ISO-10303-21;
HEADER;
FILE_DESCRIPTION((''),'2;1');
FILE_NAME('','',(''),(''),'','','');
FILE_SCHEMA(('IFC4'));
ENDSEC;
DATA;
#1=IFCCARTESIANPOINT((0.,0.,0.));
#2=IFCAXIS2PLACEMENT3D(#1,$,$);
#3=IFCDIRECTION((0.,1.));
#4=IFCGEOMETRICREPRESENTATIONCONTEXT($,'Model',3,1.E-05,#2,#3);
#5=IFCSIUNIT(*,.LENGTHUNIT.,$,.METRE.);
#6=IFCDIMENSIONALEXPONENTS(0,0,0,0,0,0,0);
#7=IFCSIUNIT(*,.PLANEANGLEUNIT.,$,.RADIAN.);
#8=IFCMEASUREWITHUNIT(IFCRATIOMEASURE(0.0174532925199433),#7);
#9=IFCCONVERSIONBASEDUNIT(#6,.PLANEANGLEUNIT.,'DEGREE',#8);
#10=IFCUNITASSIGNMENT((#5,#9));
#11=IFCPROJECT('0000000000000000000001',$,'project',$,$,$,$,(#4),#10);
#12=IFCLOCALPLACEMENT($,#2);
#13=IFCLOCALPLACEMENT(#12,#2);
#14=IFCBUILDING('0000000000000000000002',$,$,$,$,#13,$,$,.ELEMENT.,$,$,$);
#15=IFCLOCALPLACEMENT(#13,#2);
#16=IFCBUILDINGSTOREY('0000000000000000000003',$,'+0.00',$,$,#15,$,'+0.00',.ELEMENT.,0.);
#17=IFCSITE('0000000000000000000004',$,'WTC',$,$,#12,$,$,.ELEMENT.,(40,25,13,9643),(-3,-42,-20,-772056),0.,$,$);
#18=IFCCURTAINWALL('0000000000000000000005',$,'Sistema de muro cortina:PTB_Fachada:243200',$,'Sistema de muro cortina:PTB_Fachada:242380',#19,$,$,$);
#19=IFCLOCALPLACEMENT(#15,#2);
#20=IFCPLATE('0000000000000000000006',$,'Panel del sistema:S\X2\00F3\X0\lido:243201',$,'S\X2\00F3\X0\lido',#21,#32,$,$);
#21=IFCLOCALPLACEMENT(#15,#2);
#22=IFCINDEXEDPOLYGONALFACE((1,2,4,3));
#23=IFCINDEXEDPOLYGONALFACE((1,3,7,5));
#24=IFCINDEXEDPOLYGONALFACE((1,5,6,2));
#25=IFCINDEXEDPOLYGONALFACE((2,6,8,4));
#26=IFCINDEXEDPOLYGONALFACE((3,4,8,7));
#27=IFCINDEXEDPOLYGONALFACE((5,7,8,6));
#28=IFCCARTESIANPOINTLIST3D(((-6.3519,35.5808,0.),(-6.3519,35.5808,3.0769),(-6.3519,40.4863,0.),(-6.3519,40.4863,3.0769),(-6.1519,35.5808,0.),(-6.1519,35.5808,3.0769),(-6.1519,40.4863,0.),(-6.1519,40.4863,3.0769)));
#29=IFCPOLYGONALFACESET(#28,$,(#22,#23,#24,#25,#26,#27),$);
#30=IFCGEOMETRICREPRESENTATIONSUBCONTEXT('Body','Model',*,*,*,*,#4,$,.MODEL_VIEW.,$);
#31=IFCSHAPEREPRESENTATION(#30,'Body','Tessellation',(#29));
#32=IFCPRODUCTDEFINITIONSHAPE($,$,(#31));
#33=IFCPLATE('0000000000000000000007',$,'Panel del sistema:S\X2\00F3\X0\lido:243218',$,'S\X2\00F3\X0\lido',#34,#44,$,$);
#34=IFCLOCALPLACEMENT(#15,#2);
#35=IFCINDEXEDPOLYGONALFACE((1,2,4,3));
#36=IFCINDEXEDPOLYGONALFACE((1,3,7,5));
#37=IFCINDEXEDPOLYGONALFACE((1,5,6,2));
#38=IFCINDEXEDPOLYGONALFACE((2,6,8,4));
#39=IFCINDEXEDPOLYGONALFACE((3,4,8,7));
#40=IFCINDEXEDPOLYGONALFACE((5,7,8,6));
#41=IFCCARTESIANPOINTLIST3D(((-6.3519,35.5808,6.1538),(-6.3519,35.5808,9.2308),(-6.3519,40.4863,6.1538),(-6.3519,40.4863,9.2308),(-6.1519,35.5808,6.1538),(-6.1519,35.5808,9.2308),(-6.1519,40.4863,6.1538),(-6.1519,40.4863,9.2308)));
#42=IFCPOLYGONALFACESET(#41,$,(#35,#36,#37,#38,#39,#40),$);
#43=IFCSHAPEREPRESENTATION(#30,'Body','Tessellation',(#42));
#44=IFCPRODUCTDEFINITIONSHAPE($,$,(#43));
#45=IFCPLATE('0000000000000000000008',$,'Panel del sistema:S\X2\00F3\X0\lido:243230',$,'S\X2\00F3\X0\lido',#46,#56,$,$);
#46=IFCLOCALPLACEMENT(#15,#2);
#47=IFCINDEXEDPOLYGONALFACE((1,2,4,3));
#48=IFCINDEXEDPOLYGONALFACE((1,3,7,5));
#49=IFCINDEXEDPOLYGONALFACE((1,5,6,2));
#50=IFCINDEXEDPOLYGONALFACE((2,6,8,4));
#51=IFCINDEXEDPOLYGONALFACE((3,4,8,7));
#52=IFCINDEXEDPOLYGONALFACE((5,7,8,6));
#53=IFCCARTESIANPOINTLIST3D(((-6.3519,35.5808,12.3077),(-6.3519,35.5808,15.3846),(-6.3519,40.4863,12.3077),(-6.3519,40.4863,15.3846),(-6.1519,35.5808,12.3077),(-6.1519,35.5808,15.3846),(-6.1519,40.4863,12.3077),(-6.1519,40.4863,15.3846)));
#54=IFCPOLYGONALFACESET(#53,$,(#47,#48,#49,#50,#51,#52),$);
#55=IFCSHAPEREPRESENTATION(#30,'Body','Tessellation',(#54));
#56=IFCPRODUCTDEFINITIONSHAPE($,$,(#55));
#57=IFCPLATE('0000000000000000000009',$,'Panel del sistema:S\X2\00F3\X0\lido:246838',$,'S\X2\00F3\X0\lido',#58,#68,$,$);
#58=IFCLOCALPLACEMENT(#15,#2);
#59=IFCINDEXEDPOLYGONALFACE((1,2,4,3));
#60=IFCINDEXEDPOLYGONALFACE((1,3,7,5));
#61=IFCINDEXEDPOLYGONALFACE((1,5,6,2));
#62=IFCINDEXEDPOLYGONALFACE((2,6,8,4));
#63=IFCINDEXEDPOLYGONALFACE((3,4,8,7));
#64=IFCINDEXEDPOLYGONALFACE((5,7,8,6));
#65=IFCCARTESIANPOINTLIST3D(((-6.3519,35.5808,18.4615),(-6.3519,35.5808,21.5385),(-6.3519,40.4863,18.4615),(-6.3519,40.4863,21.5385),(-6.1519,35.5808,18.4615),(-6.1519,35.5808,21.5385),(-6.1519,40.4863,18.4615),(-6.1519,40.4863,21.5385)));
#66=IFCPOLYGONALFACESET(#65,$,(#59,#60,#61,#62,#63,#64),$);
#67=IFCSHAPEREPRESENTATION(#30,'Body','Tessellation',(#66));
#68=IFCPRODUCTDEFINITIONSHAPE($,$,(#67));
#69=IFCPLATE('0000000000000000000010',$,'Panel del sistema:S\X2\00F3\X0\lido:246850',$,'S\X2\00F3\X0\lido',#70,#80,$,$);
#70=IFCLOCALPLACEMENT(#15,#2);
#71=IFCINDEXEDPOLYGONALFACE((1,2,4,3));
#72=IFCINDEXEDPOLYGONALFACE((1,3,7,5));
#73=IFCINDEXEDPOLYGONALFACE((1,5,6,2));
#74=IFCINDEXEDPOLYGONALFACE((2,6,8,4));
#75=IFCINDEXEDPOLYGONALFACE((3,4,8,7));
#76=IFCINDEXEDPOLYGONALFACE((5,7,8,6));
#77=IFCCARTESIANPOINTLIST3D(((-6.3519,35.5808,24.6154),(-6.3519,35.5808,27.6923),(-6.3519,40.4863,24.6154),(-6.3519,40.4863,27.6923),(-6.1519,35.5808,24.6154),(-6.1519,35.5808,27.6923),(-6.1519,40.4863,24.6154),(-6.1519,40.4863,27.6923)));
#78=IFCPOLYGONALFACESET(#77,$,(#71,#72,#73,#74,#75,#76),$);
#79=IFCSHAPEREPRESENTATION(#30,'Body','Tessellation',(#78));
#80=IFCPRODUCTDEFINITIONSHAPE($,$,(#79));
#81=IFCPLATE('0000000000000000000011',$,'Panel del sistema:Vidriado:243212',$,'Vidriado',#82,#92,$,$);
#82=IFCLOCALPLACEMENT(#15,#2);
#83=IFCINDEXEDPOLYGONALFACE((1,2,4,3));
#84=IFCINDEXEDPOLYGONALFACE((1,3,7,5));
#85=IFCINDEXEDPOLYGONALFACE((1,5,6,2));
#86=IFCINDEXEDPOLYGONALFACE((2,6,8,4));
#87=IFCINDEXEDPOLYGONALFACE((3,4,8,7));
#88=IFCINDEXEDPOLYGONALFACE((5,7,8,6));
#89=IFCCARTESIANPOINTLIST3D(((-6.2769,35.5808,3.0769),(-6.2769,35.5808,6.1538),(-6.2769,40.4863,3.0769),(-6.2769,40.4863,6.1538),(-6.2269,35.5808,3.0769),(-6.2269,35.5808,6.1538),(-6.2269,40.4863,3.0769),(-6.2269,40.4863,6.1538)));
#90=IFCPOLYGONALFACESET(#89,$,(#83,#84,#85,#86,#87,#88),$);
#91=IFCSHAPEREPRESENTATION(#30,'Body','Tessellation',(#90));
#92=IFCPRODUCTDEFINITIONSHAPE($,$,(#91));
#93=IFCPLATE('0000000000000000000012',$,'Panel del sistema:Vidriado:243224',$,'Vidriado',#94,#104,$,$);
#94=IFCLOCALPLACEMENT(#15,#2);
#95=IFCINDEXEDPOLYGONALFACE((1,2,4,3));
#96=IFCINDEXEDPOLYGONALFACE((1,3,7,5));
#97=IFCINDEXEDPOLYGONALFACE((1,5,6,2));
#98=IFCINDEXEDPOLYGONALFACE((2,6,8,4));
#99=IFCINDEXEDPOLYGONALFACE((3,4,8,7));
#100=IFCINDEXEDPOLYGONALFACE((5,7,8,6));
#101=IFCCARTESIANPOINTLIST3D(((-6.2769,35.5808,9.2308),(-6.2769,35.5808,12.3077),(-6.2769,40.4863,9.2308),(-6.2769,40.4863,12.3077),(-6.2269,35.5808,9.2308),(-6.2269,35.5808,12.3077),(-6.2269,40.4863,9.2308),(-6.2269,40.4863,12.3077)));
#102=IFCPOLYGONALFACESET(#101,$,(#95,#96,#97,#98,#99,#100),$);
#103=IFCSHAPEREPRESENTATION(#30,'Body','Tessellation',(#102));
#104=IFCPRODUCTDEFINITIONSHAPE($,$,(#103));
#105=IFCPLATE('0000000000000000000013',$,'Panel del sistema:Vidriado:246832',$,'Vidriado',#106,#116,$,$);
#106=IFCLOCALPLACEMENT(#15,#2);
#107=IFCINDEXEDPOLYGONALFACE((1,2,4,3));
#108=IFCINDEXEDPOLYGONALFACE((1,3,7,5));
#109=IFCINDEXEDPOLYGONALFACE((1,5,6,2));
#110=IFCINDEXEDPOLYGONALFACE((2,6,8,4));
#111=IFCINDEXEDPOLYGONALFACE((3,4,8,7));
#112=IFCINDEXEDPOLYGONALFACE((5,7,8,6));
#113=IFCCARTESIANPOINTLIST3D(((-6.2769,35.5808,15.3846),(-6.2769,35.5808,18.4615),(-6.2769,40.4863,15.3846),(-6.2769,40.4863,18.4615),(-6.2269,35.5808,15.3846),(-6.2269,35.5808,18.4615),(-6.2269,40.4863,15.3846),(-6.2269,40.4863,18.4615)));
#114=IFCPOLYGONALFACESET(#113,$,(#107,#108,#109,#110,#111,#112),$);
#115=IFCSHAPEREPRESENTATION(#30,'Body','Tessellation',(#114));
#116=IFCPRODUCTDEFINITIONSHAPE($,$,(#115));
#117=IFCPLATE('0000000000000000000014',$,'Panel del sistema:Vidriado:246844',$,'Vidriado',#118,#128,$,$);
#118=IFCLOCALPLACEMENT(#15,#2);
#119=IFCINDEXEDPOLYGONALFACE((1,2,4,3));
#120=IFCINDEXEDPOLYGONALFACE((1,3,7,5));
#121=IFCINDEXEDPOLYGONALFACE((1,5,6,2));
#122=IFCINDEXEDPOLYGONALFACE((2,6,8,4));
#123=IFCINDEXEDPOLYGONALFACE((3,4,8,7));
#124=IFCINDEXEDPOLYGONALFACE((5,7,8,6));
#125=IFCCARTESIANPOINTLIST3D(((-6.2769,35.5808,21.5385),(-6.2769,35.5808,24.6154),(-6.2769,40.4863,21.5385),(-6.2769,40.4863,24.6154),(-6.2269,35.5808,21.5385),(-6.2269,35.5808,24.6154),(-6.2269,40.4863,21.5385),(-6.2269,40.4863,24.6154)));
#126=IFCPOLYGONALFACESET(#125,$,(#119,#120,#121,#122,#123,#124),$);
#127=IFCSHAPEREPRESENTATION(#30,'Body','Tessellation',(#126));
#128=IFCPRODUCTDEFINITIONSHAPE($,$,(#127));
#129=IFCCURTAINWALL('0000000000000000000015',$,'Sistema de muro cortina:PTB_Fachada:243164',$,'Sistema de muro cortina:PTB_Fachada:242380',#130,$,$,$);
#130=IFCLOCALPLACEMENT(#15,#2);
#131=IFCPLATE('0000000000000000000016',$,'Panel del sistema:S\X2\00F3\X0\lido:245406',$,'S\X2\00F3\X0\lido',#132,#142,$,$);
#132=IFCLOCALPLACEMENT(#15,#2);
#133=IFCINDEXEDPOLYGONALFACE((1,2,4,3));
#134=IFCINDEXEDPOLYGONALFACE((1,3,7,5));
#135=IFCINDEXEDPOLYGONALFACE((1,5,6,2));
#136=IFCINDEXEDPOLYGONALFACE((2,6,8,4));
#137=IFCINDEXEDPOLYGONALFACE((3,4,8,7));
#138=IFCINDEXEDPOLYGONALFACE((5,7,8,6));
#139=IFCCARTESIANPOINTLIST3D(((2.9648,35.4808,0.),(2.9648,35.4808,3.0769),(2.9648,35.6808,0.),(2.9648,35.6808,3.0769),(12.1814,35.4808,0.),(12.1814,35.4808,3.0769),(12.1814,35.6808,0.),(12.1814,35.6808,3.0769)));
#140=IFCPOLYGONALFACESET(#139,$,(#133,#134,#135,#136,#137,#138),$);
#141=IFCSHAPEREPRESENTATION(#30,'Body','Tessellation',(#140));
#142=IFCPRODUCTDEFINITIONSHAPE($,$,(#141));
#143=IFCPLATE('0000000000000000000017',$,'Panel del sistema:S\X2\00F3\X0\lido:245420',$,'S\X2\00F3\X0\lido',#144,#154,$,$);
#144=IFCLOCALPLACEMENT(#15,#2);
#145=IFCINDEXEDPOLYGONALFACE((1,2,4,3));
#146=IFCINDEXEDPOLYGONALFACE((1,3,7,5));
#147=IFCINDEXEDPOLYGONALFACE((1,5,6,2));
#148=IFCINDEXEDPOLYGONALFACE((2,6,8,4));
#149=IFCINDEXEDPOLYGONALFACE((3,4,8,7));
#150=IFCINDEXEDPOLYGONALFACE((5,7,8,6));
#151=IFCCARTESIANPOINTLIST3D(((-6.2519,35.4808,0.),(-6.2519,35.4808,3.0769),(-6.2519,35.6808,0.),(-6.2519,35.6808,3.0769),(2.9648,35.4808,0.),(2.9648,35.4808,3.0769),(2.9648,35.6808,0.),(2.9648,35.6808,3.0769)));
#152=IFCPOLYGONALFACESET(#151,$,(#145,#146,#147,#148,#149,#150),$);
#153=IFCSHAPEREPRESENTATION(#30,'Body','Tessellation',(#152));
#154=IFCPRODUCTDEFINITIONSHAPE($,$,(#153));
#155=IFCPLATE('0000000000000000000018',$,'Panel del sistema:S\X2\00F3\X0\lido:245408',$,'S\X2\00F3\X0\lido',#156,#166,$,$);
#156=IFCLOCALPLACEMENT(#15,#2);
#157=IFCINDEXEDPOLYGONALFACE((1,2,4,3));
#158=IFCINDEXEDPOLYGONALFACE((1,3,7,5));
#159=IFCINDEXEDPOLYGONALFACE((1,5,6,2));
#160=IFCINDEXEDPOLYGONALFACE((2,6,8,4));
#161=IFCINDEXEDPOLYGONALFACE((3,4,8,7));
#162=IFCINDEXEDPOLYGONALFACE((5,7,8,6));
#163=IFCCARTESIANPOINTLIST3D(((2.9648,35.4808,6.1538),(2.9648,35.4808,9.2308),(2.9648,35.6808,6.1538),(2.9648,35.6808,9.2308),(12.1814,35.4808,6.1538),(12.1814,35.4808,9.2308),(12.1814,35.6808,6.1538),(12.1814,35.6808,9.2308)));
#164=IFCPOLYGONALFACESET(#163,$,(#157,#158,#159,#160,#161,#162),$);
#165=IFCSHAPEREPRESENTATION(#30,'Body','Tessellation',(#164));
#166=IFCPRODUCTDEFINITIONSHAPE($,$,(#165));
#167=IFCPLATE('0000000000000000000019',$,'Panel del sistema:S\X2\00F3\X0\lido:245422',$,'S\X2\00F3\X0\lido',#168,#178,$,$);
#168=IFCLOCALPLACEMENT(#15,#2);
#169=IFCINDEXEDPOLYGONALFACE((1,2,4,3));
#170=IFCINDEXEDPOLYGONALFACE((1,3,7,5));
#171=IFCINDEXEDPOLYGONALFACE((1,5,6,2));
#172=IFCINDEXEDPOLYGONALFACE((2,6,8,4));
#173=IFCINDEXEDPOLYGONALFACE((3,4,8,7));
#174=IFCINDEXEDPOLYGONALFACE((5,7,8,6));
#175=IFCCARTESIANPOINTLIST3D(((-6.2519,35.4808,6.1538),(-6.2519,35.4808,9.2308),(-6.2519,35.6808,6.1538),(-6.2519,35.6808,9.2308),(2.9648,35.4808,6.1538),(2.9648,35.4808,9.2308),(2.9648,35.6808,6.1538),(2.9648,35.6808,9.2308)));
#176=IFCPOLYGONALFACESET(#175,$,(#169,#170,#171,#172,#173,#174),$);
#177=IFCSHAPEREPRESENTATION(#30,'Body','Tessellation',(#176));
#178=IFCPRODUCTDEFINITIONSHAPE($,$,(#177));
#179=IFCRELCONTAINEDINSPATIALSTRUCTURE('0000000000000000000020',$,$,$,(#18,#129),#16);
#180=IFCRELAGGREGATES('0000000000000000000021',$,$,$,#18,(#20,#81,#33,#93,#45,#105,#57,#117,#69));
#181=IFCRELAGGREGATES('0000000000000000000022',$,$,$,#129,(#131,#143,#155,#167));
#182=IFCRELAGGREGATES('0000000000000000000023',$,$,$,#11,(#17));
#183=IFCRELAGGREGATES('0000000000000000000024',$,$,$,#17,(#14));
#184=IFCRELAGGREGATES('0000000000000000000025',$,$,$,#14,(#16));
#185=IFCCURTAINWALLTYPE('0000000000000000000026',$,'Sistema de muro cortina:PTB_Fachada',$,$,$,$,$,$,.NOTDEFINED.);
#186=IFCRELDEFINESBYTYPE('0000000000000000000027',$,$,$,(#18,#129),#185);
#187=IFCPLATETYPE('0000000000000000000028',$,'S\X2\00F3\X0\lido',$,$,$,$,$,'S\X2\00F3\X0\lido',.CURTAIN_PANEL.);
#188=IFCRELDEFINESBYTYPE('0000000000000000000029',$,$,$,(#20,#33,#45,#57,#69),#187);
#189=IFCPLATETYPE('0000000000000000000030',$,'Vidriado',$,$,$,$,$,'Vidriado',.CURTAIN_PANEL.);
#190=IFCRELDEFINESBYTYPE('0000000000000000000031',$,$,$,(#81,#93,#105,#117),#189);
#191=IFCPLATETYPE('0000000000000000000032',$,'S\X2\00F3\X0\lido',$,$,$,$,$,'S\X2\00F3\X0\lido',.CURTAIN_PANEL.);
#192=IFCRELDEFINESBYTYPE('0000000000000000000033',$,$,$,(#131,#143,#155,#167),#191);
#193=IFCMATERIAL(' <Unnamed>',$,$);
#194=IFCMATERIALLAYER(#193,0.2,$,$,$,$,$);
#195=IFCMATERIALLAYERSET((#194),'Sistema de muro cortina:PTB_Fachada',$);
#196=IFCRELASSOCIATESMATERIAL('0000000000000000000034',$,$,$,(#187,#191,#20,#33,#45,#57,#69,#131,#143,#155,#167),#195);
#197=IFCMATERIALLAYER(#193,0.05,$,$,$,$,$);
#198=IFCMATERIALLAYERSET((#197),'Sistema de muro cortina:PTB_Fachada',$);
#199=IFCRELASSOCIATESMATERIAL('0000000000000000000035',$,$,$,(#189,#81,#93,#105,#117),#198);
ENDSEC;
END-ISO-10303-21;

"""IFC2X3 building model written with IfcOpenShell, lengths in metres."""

from ifc_helpers import new_model, entity, si_unit, converted_unit, direction, frame, origin, origin_2d_with_axis, place, context, subcontext, project, spatial, rectangle, extrude, source, transform, mapped, material, layer, layer_set, layer_usage, type_object, type_shapes, element, aggregate, save


model = new_model("IFC2X3")

# Units and contexts
model_context = context("Model", 3, precision=1e-05, world=origin(), true_north=direction((0.0, 1.0)))
body_context = subcontext(model_context, "Body", "Model", "MODEL_VIEW")
ifc_project = project(units=[si_unit("LENGTHUNIT", "METRE"), converted_unit("PLANEANGLEUNIT", "DEGREE", entity("IfcRatioMeasure", 0.0174532925199433), si_unit("PLANEANGLEUNIT", "RADIAN"), dimensions=[0, 0, 0, 0, 0, 0, 0])], contexts=[model_context])

# Site, building, storey
site_placement = place(None, origin())
site = spatial("IfcSite", under=ifc_project, at=site_placement, Name="WTC", CompositionType="ELEMENT", RefLatitude=(40, 25, 13, 9643), RefLongitude=(-3, -42, -20, -772056), RefElevation=0.0)
building_placement = place(site_placement, origin())
building = spatial("IfcBuilding", under=site, at=building_placement, CompositionType="ELEMENT")
storey_placement = place(building_placement, origin())
storey = spatial("IfcBuildingStorey", under=building, at=storey_placement, Name="+0.00", LongName="+0.00", CompositionType="ELEMENT", Elevation=0.0)

# Curtain walls, plates
curtain_wall_type = type_object("IfcCurtainWallType", Name="Sistema de muro cortina:PTB_Fachada", PredefinedType="NOTDEFINED")
curtain_wall_1_placement = place(storey_placement, origin())
curtain_wall_1 = element("IfcCurtainWall", 1, at=curtain_wall_1_placement, inside=storey, type_object=curtain_wall_type, Name="Sistema de muro cortina:PTB_Fachada:243200", ObjectType="Sistema de muro cortina:PTB_Fachada:242380")
ifc_material_1 = material(Name=" <Unnamed>")
ifc_layer_1 = layer(ifc_material_1, 0.2)
ifc_layer_set_1 = layer_set([ifc_layer_1], Name="Sistema de muro cortina:PTB_Fachada")
ifc_layer_usage_1 = layer_usage(ifc_layer_set_1, "AXIS3", "POSITIVE", 0.0)
plate_type_1 = type_object("IfcPlateType", Name="Sólido", ElementType="Sólido", PredefinedType="CURTAIN_PANEL", material=ifc_layer_set_1)
shared_shape_1 = source(origin(), body_context, "Body", "SweptSolid", [
    extrude(rectangle(XDim=0.2, YDim=4.9055, at=origin_2d_with_axis()), frame((0.0, 0.0, 0.0), z_axis=(0.0, 0.0, 1.0), x_axis=(0.0, 1.0, 0.0)), (0.0, 0.0, 1.0), 3.0769),
])
type_shapes(plate_type_1, [shared_shape_1])
plate_1_placement = place(curtain_wall_1_placement, frame((-6.2519, 38.0336, 0.0), z_axis=(0.0, 0.0, 1.0), x_axis=(0.0, 1.0, 0.0)))
plate_1 = element("IfcPlate", 2, at=plate_1_placement, type_object=plate_type_1, material=ifc_layer_usage_1, Name="Panel del sistema:Sólido:243201", ObjectType="Sólido", context=body_context, shape_type="MappedRepresentation", body=[
    mapped(shared_shape_1, transform((0.0, 0.0, 0.0), scale=1.0)),
])
ifc_layer_usage_2 = layer_usage(ifc_layer_set_1, "AXIS3", "POSITIVE", 0.0)
plate_2_placement = place(curtain_wall_1_placement, frame((-6.2519, 38.0336, 6.1538), z_axis=(0.0, 0.0, 1.0), x_axis=(0.0, 1.0, 0.0)))
plate_2 = element("IfcPlate", 3, at=plate_2_placement, type_object=plate_type_1, material=ifc_layer_usage_2, Name="Panel del sistema:Sólido:243218", ObjectType="Sólido", context=body_context, shape_type="MappedRepresentation", body=[
    mapped(shared_shape_1, transform((0.0, 0.0, 0.0), scale=1.0)),
])
ifc_layer_usage_3 = layer_usage(ifc_layer_set_1, "AXIS3", "POSITIVE", 0.0)
plate_3_placement = place(curtain_wall_1_placement, frame((-6.2519, 38.0336, 12.3077), z_axis=(0.0, 0.0, 1.0), x_axis=(0.0, 1.0, 0.0)))
plate_3 = element("IfcPlate", 4, at=plate_3_placement, type_object=plate_type_1, material=ifc_layer_usage_3, Name="Panel del sistema:Sólido:243230", ObjectType="Sólido", context=body_context, shape_type="MappedRepresentation", body=[
    mapped(shared_shape_1, transform((0.0, 0.0, 0.0), scale=1.0)),
])
ifc_layer_usage_4 = layer_usage(ifc_layer_set_1, "AXIS3", "POSITIVE", 0.0)
plate_4_placement = place(curtain_wall_1_placement, frame((-6.2519, 38.0336, 18.4615), z_axis=(0.0, 0.0, 1.0), x_axis=(0.0, 1.0, 0.0)))
plate_4 = element("IfcPlate", 5, at=plate_4_placement, type_object=plate_type_1, material=ifc_layer_usage_4, Name="Panel del sistema:Sólido:246838", ObjectType="Sólido", context=body_context, shape_type="MappedRepresentation", body=[
    mapped(shared_shape_1, transform((0.0, 0.0, 0.0), scale=1.0)),
])
ifc_layer_usage_5 = layer_usage(ifc_layer_set_1, "AXIS3", "POSITIVE", 0.0)
plate_5_placement = place(curtain_wall_1_placement, frame((-6.2519, 38.0336, 24.6154), z_axis=(0.0, 0.0, 1.0), x_axis=(0.0, 1.0, 0.0)))
plate_5 = element("IfcPlate", 6, at=plate_5_placement, type_object=plate_type_1, material=ifc_layer_usage_5, Name="Panel del sistema:Sólido:246850", ObjectType="Sólido", context=body_context, shape_type="MappedRepresentation", body=[
    mapped(shared_shape_1, transform((0.0, 0.0, 0.0), scale=1.0)),
])
ifc_layer_2 = layer(ifc_material_1, 0.05)
ifc_layer_set_2 = layer_set([ifc_layer_2], Name="Sistema de muro cortina:PTB_Fachada")
ifc_layer_usage_6 = layer_usage(ifc_layer_set_2, "AXIS3", "POSITIVE", 0.0)
plate_type_2 = type_object("IfcPlateType", Name="Vidriado", ElementType="Vidriado", PredefinedType="CURTAIN_PANEL", material=ifc_layer_set_2)
shared_shape_2 = source(origin(), body_context, "Body", "SweptSolid", [
    extrude(rectangle(XDim=0.05, YDim=4.9055, at=origin_2d_with_axis()), frame((0.0, 0.0, 0.0), z_axis=(0.0, 0.0, 1.0), x_axis=(0.0, 1.0, 0.0)), (0.0, 0.0, 1.0), 3.0769),
])
type_shapes(plate_type_2, [shared_shape_2])
plate_6_placement = place(curtain_wall_1_placement, frame((-6.2519, 38.0336, 3.0769), z_axis=(0.0, 0.0, 1.0), x_axis=(0.0, 1.0, 0.0)))
plate_6 = element("IfcPlate", 7, at=plate_6_placement, type_object=plate_type_2, material=ifc_layer_usage_6, Name="Panel del sistema:Vidriado:243212", ObjectType="Vidriado", context=body_context, shape_type="MappedRepresentation", body=[
    mapped(shared_shape_2, transform((0.0, 0.0, 0.0), scale=1.0)),
])
ifc_layer_usage_7 = layer_usage(ifc_layer_set_2, "AXIS3", "POSITIVE", 0.0)
plate_7_placement = place(curtain_wall_1_placement, frame((-6.2519, 38.0336, 9.2308), z_axis=(0.0, 0.0, 1.0), x_axis=(0.0, 1.0, 0.0)))
plate_7 = element("IfcPlate", 8, at=plate_7_placement, type_object=plate_type_2, material=ifc_layer_usage_7, Name="Panel del sistema:Vidriado:243224", ObjectType="Vidriado", context=body_context, shape_type="MappedRepresentation", body=[
    mapped(shared_shape_2, transform((0.0, 0.0, 0.0), scale=1.0)),
])
ifc_layer_usage_8 = layer_usage(ifc_layer_set_2, "AXIS3", "POSITIVE", 0.0)
plate_8_placement = place(curtain_wall_1_placement, frame((-6.2519, 38.0336, 15.3846), z_axis=(0.0, 0.0, 1.0), x_axis=(0.0, 1.0, 0.0)))
plate_8 = element("IfcPlate", 9, at=plate_8_placement, type_object=plate_type_2, material=ifc_layer_usage_8, Name="Panel del sistema:Vidriado:246832", ObjectType="Vidriado", context=body_context, shape_type="MappedRepresentation", body=[
    mapped(shared_shape_2, transform((0.0, 0.0, 0.0), scale=1.0)),
])
ifc_layer_usage_9 = layer_usage(ifc_layer_set_2, "AXIS3", "POSITIVE", 0.0)
plate_9_placement = place(curtain_wall_1_placement, frame((-6.2519, 38.0336, 21.5385), z_axis=(0.0, 0.0, 1.0), x_axis=(0.0, 1.0, 0.0)))
plate_9 = element("IfcPlate", 10, at=plate_9_placement, type_object=plate_type_2, material=ifc_layer_usage_9, Name="Panel del sistema:Vidriado:246844", ObjectType="Vidriado", context=body_context, shape_type="MappedRepresentation", body=[
    mapped(shared_shape_2, transform((0.0, 0.0, 0.0), scale=1.0)),
])
aggregate(curtain_wall_1, [plate_1, plate_6, plate_2, plate_7, plate_3, plate_8, plate_4, plate_9, plate_5])
curtain_wall_2_placement = place(storey_placement, origin())
curtain_wall_2 = element("IfcCurtainWall", 11, at=curtain_wall_2_placement, inside=storey, type_object=curtain_wall_type, Name="Sistema de muro cortina:PTB_Fachada:243164", ObjectType="Sistema de muro cortina:PTB_Fachada:242380")
ifc_layer_usage_10 = layer_usage(ifc_layer_set_1, "AXIS3", "POSITIVE", 0.0)
plate_type_3 = type_object("IfcPlateType", Name="Sólido", ElementType="Sólido", PredefinedType="CURTAIN_PANEL", material=ifc_layer_set_1)
shared_shape_3 = source(origin(), body_context, "Body", "SweptSolid", [
    extrude(rectangle(XDim=0.2, YDim=9.2166, at=origin_2d_with_axis()), frame((0.0, 0.0, 0.0), z_axis=(0.0, 0.0, 1.0), x_axis=(0.0, 1.0, 0.0)), (0.0, 0.0, 1.0), 3.0769),
])
type_shapes(plate_type_3, [shared_shape_3])
plate_10_placement = place(curtain_wall_2_placement, frame((7.5731, 35.5808, 0.0), z_axis=(0.0, 0.0, 1.0), x_axis=(-1.0, 0.0, 0.0)))
plate_10 = element("IfcPlate", 12, at=plate_10_placement, type_object=plate_type_3, material=ifc_layer_usage_10, Name="Panel del sistema:Sólido:245406", ObjectType="Sólido", context=body_context, shape_type="MappedRepresentation", body=[
    mapped(shared_shape_3, transform((0.0, 0.0, 0.0), scale=1.0)),
])
ifc_layer_usage_11 = layer_usage(ifc_layer_set_1, "AXIS3", "POSITIVE", 0.0)
plate_11_placement = place(curtain_wall_2_placement, frame((-1.6436, 35.5808, 0.0), z_axis=(0.0, 0.0, 1.0), x_axis=(-1.0, 0.0, 0.0)))
plate_11 = element("IfcPlate", 13, at=plate_11_placement, type_object=plate_type_3, material=ifc_layer_usage_11, Name="Panel del sistema:Sólido:245420", ObjectType="Sólido", context=body_context, shape_type="MappedRepresentation", body=[
    mapped(shared_shape_3, transform((0.0, 0.0, 0.0), scale=1.0)),
])
ifc_layer_usage_12 = layer_usage(ifc_layer_set_1, "AXIS3", "POSITIVE", 0.0)
plate_12_placement = place(curtain_wall_2_placement, frame((7.5731, 35.5808, 6.1538), z_axis=(0.0, 0.0, 1.0), x_axis=(-1.0, 0.0, 0.0)))
plate_12 = element("IfcPlate", 14, at=plate_12_placement, type_object=plate_type_3, material=ifc_layer_usage_12, Name="Panel del sistema:Sólido:245408", ObjectType="Sólido", context=body_context, shape_type="MappedRepresentation", body=[
    mapped(shared_shape_3, transform((0.0, 0.0, 0.0), scale=1.0)),
])
ifc_layer_usage_13 = layer_usage(ifc_layer_set_1, "AXIS3", "POSITIVE", 0.0)
plate_13_placement = place(curtain_wall_2_placement, frame((-1.6436, 35.5808, 6.1538), z_axis=(0.0, 0.0, 1.0), x_axis=(-1.0, 0.0, 0.0)))
plate_13 = element("IfcPlate", 15, at=plate_13_placement, type_object=plate_type_3, material=ifc_layer_usage_13, Name="Panel del sistema:Sólido:245422", ObjectType="Sólido", context=body_context, shape_type="MappedRepresentation", body=[
    mapped(shared_shape_3, transform((0.0, 0.0, 0.0), scale=1.0)),
])
aggregate(curtain_wall_2, [plate_10, plate_11, plate_12, plate_13])

save(model, "model.ifc")
